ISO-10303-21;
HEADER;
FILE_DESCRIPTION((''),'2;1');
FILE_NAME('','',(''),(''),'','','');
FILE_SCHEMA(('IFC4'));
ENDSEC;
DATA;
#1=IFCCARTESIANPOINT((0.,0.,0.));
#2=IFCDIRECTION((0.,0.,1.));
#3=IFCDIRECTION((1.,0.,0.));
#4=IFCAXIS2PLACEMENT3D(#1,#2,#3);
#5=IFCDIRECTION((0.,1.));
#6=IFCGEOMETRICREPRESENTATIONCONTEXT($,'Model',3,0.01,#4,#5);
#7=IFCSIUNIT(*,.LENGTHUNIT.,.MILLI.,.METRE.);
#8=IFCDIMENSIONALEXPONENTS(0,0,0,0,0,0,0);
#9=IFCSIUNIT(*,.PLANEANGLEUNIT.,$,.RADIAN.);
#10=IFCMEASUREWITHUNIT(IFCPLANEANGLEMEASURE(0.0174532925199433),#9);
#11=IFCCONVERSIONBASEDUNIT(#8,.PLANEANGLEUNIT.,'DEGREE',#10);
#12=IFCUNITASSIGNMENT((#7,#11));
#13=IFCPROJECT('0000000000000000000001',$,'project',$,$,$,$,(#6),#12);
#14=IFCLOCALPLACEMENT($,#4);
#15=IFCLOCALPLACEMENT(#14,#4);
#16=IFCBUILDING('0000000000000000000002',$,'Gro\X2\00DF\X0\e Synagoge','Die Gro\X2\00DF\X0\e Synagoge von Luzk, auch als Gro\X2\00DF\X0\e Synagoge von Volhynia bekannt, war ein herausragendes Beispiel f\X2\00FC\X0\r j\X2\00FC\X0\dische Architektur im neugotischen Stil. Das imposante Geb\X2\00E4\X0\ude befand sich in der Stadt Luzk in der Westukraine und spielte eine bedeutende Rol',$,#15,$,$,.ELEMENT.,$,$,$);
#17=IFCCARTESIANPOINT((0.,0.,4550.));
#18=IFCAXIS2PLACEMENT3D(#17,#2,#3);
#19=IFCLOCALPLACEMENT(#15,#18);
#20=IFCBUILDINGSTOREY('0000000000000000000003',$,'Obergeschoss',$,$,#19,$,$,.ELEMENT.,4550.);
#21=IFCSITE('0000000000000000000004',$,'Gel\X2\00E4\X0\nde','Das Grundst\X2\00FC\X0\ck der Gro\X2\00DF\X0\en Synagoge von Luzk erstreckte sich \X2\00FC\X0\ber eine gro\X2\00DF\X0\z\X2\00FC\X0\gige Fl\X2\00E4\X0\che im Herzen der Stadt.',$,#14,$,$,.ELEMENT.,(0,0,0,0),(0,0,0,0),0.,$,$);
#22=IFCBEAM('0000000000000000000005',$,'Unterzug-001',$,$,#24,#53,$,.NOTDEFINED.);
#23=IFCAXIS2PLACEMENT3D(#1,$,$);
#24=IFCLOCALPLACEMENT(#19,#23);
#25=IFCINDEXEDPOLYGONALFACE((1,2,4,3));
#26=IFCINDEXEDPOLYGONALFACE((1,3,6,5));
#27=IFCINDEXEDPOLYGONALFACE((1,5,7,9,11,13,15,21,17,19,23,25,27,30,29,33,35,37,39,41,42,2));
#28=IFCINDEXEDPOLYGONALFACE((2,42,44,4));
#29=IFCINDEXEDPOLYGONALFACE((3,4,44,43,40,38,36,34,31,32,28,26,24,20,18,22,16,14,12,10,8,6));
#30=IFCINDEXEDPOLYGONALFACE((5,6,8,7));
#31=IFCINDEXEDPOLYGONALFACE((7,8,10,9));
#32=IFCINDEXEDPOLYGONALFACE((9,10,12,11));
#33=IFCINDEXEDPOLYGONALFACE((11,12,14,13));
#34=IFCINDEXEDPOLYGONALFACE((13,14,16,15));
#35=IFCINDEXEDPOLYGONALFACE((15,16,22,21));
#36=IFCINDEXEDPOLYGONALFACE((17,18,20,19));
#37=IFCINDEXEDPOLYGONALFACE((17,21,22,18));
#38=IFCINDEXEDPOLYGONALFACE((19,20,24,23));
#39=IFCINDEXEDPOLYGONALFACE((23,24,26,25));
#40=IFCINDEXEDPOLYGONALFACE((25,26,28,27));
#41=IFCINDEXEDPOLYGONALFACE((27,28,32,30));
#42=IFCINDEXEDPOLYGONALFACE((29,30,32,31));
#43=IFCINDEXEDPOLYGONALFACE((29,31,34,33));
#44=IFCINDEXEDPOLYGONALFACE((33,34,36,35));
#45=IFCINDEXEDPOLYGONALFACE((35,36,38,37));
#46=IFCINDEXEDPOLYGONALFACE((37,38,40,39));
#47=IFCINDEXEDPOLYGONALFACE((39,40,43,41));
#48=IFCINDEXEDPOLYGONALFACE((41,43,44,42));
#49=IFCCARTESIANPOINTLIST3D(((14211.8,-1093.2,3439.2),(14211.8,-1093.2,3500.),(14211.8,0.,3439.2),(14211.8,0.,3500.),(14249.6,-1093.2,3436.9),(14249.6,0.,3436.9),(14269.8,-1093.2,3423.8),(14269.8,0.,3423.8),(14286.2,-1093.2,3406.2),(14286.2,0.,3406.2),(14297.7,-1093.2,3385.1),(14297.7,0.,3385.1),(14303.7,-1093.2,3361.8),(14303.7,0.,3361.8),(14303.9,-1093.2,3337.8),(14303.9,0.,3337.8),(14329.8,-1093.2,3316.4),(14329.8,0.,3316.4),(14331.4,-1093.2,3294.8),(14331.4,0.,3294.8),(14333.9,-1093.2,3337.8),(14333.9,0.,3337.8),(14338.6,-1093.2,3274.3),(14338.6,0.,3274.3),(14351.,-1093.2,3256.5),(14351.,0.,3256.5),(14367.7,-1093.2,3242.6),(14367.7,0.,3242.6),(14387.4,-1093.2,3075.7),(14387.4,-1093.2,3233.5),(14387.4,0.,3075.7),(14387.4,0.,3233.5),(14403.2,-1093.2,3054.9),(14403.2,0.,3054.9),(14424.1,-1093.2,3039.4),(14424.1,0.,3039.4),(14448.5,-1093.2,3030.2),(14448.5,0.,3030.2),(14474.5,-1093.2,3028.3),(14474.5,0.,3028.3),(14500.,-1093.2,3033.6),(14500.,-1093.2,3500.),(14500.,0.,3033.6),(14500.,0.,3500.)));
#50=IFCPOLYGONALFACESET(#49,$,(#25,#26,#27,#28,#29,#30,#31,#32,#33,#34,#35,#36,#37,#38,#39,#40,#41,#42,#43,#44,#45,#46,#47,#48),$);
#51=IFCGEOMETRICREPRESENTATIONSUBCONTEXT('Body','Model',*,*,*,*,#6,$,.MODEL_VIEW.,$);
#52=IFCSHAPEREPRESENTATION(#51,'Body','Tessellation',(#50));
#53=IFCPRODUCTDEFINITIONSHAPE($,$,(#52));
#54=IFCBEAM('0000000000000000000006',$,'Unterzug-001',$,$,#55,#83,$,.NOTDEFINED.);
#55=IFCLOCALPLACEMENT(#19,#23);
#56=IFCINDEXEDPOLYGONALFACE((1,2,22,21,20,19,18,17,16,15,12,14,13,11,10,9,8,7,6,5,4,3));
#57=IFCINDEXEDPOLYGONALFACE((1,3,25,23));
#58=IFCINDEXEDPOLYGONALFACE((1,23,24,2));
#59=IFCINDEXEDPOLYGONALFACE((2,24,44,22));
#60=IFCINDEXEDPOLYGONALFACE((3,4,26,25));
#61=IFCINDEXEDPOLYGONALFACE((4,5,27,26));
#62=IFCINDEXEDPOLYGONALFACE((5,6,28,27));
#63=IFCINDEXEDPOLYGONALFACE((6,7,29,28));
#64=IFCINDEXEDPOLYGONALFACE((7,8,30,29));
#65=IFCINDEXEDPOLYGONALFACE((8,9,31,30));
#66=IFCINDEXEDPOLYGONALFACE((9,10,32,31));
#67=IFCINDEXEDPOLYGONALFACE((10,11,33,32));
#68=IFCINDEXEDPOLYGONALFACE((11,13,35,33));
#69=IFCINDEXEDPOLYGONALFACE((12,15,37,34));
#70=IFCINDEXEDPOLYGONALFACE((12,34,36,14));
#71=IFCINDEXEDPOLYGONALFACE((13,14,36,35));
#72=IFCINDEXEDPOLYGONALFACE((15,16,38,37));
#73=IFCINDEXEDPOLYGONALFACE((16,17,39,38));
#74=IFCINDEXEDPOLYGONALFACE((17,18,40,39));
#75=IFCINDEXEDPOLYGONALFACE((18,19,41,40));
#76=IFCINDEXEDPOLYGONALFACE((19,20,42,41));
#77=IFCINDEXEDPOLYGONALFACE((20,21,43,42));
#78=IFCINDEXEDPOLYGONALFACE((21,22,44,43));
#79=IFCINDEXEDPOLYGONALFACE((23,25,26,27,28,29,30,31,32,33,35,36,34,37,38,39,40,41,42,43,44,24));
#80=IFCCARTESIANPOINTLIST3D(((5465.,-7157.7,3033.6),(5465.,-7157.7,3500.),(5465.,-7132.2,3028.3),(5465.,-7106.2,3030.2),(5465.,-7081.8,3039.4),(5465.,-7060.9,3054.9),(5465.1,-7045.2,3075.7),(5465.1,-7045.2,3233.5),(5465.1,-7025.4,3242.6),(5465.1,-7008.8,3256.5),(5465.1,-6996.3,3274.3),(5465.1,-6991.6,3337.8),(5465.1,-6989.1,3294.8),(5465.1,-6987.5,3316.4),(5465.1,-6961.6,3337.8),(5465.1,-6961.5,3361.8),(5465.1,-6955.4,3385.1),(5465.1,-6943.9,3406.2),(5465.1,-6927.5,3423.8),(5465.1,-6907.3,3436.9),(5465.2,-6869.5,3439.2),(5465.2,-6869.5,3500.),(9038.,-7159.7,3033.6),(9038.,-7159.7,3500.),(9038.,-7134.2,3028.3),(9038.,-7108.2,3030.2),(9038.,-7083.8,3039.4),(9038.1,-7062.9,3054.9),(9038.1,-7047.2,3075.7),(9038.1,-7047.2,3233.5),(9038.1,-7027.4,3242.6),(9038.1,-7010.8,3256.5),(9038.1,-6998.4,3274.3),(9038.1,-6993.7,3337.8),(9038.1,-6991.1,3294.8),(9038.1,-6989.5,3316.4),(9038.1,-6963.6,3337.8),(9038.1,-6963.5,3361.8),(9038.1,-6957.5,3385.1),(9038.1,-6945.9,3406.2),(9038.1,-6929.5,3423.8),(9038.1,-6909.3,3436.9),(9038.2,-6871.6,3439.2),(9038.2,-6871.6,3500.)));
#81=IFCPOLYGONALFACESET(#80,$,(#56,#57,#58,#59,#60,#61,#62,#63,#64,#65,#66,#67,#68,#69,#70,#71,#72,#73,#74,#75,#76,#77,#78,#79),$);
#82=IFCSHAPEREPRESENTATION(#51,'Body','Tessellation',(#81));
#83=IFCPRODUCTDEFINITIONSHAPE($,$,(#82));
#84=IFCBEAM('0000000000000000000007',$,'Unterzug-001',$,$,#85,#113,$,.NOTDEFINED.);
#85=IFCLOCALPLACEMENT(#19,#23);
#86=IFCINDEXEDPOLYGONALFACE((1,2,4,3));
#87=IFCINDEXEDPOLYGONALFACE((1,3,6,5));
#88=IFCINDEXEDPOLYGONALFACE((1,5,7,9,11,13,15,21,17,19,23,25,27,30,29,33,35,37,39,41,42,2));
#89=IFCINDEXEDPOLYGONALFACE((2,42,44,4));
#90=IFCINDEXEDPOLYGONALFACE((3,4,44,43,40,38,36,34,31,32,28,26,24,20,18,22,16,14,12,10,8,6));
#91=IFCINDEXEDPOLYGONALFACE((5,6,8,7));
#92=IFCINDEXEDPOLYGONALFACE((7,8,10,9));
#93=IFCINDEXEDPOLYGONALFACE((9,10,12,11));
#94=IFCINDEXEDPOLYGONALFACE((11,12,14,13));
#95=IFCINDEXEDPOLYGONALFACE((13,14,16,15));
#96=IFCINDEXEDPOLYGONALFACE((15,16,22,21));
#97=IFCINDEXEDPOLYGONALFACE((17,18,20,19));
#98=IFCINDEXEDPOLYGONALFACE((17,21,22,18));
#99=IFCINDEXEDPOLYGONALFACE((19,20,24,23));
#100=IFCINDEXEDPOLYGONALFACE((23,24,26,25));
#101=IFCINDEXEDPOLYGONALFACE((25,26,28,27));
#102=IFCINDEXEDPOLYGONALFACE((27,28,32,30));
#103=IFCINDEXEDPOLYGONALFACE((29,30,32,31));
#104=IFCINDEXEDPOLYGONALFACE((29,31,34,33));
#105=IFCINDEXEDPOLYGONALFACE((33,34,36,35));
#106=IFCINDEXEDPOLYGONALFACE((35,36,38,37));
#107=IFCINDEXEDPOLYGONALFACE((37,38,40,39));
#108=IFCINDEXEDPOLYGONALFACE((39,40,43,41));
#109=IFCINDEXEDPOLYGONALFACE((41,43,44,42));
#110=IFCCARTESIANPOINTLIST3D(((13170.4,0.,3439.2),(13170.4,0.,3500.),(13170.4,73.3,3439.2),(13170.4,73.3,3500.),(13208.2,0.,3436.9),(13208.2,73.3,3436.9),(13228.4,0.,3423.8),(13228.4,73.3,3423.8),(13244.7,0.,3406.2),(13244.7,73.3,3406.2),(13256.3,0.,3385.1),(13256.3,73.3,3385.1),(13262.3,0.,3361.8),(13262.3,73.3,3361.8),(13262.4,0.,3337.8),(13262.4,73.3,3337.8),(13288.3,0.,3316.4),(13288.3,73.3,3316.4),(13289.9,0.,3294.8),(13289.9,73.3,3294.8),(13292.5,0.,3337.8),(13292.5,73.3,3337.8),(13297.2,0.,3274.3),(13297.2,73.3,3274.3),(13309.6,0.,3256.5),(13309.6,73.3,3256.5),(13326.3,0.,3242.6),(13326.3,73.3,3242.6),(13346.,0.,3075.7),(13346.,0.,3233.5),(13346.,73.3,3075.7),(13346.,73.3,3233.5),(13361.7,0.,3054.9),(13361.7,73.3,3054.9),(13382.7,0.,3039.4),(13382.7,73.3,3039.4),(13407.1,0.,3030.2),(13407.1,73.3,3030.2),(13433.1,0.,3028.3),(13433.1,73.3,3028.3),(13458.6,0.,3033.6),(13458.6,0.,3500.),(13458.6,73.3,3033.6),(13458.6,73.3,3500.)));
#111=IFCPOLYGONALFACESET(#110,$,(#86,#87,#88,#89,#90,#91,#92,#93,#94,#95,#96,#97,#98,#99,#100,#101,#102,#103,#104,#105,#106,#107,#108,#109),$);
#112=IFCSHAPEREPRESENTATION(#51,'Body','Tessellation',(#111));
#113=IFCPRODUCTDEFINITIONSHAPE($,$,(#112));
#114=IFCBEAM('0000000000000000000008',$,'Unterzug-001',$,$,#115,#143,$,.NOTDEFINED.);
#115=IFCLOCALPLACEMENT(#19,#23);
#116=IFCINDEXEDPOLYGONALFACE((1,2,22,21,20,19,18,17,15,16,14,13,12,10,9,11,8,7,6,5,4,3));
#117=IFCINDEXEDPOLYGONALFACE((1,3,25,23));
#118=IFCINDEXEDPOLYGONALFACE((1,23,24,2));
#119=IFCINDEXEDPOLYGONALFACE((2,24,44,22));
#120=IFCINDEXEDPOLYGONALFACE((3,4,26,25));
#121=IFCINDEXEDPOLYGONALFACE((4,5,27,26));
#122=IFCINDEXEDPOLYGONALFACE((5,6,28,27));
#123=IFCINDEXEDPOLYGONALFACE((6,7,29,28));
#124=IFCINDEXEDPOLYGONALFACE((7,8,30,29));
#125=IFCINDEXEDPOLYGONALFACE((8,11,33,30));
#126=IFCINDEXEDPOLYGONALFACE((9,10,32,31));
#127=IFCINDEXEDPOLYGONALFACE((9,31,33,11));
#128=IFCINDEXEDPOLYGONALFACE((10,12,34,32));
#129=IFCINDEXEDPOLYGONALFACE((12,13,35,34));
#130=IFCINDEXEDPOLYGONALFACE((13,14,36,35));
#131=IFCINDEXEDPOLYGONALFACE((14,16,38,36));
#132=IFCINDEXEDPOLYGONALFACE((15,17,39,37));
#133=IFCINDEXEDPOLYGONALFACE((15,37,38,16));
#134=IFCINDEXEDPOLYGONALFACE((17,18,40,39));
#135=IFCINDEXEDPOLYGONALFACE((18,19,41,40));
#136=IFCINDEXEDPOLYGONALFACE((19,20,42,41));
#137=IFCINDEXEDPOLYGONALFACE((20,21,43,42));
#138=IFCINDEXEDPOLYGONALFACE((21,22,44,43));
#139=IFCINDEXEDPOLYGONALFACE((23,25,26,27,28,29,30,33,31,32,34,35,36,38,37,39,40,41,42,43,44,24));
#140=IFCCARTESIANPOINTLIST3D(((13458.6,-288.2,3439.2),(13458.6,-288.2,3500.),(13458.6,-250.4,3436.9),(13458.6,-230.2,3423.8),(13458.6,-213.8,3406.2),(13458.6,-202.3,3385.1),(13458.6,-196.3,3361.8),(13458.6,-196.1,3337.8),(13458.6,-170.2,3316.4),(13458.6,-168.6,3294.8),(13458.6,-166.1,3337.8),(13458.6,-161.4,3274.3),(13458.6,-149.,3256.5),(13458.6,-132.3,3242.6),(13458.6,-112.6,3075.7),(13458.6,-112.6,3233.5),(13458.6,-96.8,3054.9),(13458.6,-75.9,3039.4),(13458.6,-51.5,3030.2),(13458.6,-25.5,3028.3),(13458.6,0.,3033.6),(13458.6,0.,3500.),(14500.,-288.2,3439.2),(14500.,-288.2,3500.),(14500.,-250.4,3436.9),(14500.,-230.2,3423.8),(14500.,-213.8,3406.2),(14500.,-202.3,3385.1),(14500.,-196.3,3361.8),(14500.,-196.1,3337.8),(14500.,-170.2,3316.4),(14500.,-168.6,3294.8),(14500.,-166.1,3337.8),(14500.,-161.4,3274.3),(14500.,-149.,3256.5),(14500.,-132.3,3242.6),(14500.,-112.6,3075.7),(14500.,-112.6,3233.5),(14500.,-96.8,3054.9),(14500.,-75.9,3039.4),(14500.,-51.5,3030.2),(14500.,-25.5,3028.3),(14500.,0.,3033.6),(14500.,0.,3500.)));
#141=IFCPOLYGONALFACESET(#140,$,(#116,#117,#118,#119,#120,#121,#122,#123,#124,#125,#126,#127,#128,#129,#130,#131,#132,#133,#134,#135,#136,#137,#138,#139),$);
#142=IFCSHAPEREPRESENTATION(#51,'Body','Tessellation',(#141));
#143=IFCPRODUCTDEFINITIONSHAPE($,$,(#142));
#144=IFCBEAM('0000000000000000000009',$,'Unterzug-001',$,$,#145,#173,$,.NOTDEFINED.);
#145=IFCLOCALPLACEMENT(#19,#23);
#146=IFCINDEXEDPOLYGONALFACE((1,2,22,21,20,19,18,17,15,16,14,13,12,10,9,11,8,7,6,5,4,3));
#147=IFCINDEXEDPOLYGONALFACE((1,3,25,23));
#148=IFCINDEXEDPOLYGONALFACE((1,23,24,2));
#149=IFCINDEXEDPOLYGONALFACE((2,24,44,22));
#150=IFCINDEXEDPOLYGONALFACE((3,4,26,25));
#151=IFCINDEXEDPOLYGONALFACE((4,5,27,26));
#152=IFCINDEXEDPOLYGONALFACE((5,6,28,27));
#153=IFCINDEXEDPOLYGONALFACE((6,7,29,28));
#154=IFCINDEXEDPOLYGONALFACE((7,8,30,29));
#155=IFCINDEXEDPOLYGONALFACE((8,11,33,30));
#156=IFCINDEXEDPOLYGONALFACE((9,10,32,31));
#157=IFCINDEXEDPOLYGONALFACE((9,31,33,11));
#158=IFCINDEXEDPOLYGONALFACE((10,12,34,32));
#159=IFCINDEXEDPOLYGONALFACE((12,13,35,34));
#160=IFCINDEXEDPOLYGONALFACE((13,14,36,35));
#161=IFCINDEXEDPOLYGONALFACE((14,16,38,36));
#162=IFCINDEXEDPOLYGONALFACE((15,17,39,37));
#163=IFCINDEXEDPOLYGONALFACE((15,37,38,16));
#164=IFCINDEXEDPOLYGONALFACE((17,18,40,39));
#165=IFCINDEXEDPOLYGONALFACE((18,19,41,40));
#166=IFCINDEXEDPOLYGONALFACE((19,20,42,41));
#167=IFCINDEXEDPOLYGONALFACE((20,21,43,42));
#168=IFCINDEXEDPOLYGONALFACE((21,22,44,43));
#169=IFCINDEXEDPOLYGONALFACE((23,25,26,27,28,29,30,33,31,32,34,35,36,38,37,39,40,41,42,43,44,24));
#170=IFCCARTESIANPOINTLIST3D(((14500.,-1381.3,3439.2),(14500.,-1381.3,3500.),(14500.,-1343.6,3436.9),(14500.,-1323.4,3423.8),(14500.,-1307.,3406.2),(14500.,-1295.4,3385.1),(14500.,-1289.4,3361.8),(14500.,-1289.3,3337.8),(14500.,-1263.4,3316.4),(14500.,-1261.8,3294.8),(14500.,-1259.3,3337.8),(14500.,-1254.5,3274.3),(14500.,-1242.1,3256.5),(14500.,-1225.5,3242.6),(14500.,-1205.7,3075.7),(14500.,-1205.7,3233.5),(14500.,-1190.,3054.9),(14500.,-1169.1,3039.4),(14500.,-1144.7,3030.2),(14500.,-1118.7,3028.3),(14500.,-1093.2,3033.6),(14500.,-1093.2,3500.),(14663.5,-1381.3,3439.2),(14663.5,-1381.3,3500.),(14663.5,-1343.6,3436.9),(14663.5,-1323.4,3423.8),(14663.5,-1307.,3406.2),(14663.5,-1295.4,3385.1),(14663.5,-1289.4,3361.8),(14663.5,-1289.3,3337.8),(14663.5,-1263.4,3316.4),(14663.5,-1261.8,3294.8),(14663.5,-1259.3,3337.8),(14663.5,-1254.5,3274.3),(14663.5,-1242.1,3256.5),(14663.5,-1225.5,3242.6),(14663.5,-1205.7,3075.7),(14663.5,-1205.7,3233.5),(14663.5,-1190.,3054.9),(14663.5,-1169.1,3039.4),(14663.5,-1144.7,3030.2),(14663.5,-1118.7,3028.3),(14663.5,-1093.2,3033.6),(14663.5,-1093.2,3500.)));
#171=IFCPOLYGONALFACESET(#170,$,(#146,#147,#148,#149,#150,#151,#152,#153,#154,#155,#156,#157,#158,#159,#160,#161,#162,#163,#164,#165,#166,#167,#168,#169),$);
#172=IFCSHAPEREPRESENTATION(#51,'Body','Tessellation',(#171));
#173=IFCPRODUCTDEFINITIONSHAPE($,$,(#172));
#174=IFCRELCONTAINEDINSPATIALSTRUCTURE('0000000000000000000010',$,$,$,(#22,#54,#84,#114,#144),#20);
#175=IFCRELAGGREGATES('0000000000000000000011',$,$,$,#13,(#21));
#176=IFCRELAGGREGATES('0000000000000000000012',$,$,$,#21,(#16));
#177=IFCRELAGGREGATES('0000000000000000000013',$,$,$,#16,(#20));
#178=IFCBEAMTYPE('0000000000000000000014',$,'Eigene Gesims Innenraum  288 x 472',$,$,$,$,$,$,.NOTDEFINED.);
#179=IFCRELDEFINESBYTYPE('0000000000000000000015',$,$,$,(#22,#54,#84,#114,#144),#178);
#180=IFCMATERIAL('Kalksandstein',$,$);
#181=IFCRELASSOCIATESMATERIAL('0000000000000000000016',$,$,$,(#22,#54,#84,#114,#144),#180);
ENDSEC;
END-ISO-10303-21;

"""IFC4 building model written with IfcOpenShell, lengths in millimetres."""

from ifc_helpers import new_model, entity, si_unit, converted_unit, direction, frame, origin_with_axes, place, context, subcontext, project, spatial, line, arc, indexed_curve, outline, extrude, material, material_profile, profile_set, type_object, element, save


model = new_model("IFC4")

# Units and contexts
model_context = context("Model", 3, precision=0.01, world=origin_with_axes(), true_north=direction((0.0, 1.0)))
body_context = subcontext(model_context, "Body", "Model", "MODEL_VIEW")
ifc_project = project(units=[si_unit("LENGTHUNIT", "METRE", prefix="MILLI"), converted_unit("PLANEANGLEUNIT", "DEGREE", entity("IfcPlaneAngleMeasure", 0.0174532925199433), si_unit("PLANEANGLEUNIT", "RADIAN"), dimensions=[0, 0, 0, 0, 0, 0, 0])], contexts=[model_context])

# Site, building, storey
site_placement = place(None, origin_with_axes())
site = spatial("IfcSite", under=ifc_project, at=site_placement, Name="Gelände", Description="Das Grundstück der Großen Synagoge von Luzk erstreckte sich über eine großzügige Fläche im Herzen der Stadt.", CompositionType="ELEMENT", RefLatitude=(0, 0, 0, 0), RefLongitude=(0, 0, 0, 0), RefElevation=0.0)
building_placement = place(site_placement, origin_with_axes())
building = spatial("IfcBuilding", under=site, at=building_placement, Name="Große Synagoge", Description="Die Große Synagoge von Luzk, auch als Große Synagoge von Volhynia bekannt, war ein herausragendes Beispiel für jüdische Architektur im neugotischen Stil. Das imposante Gebäude befand sich in der Stadt Luzk in der Westukraine und spielte eine bedeutende Rol", CompositionType="ELEMENT")
storey_placement = place(building_placement, frame((0.0, 0.0, 4550.0), z_axis=(0.0, 0.0, 1.0), x_axis=(1.0, 0.0, 0.0)))
storey = spatial("IfcBuildingStorey", under=building, at=storey_placement, Name="Obergeschoss", CompositionType="ELEMENT", Elevation=4550.0)

# Beams
ifc_material_1 = material(Name="Kalksandstein")
ifc_material_profile_1 = material_profile(ifc_material_1, outline(indexed_curve([(0.0, 0.0), (0.0, -466.4), (64.0, -466.1), (112.6, -424.3), (112.6, -266.5), (161.4, -225.7), (166.1, -162.2), (196.1, -162.2), (207.4, -104.0), (250.4, -63.1), (288.2, -60.8), (288.2, 0.0)], segments=[line(1, 2), arc(2, 3, 4), line(4, 5), arc(5, 6, 7), line(7, 8), arc(8, 9, 10), line(10, 11, 12, 1)])), Name="Kalksandstein")
ifc_profile_set_1 = profile_set([ifc_material_profile_1], Name="Eigene Gesims Innenraum ")
beam_type_1 = type_object("IfcBeamType", Name="Eigene Gesims Innenraum  288 x 472", PredefinedType="NOTDEFINED")
beam_1_placement = place(storey_placement, frame((14500.0, 0.0, 3500.0), z_axis=(0.0, 0.0, 1.0), x_axis=(-1.0, 0.0, 0.0)))
element("IfcBeam", 1, at=beam_1_placement, inside=storey, type_object=beam_type_1, material=ifc_profile_set_1, Name="Unterzug-001", PredefinedType="NOTDEFINED", context=body_context, shape_type="SweptSolid", body=[
    extrude(outline(indexed_curve([(0.0, 0.0), (0.0, -466.4), (64.0, -466.1), (112.6, -424.3), (112.6, -266.5), (161.4, -225.7), (166.1, -162.2), (196.1, -162.2), (207.4, -104.0), (250.4, -63.1), (288.2, -60.8), (288.2, 0.0)], segments=[line(1, 2), arc(2, 3, 4), line(4, 5), arc(5, 6, 7), line(7, 8), arc(8, 9, 10), line(10, 11, 12, 1)])), frame((0.0, 1093.2, 0.0), z_axis=(0.0, -1.0, 0.0), x_axis=(1.0, 0.0, 0.0)), (0.0, 0.0, 1.0), 1093.2),
])
beam_2_placement = place(storey_placement, frame((9038.0, -7159.7, 3500.0), z_axis=(0.0, 0.0, 1.0), x_axis=(0.000564, 1.0, 0.0)))
element("IfcBeam", 2, at=beam_2_placement, inside=storey, type_object=beam_type_1, material=ifc_profile_set_1, Name="Unterzug-001", PredefinedType="NOTDEFINED", context=body_context, shape_type="SweptSolid", body=[
    extrude(outline(indexed_curve([(0.0, 0.0), (0.0, -466.4), (64.0, -466.1), (112.6, -424.3), (112.6, -266.5), (161.4, -225.7), (166.1, -162.2), (196.1, -162.2), (207.4, -104.0), (250.4, -63.1), (288.2, -60.8), (288.2, 0.0)], segments=[line(1, 2), arc(2, 3, 4), line(4, 5), arc(5, 6, 7), line(7, 8), arc(8, 9, 10), line(10, 11, 12, 1)])), frame((0.0, 3573.0, 0.0), z_axis=(0.0, -1.0, 0.0), x_axis=(1.0, 0.0, 0.0)), (0.0, 0.0, 1.0), 3573.0),
])
beam_3_placement = place(storey_placement, frame((13458.6, 73.3, 3500.0), z_axis=(0.0, 0.0, 1.0), x_axis=(-1.0, 0.0, 0.0)))
element("IfcBeam", 3, at=beam_3_placement, inside=storey, type_object=beam_type_1, material=ifc_profile_set_1, Name="Unterzug-001", PredefinedType="NOTDEFINED", context=body_context, shape_type="SweptSolid", body=[
    extrude(outline(indexed_curve([(0.0, 0.0), (0.0, -466.4), (64.0, -466.1), (112.6, -424.3), (112.6, -266.5), (161.4, -225.7), (166.1, -162.2), (196.1, -162.2), (207.4, -104.0), (250.4, -63.1), (288.2, -60.8), (288.2, 0.0)], segments=[line(1, 2), arc(2, 3, 4), line(4, 5), arc(5, 6, 7), line(7, 8), arc(8, 9, 10), line(10, 11, 12, 1)])), frame((0.0, 73.3, 0.0), z_axis=(0.0, -1.0, 0.0), x_axis=(1.0, 0.0, 0.0)), (0.0, 0.0, 1.0), 73.3),
])
beam_4_placement = place(storey_placement, frame((13458.6, 0.0, 3500.0), z_axis=(0.0, 0.0, 1.0), x_axis=(0.0, -1.0, 0.0)))
element("IfcBeam", 4, at=beam_4_placement, inside=storey, type_object=beam_type_1, material=ifc_profile_set_1, Name="Unterzug-001", PredefinedType="NOTDEFINED", context=body_context, shape_type="SweptSolid", body=[
    extrude(outline(indexed_curve([(0.0, 0.0), (0.0, -466.4), (64.0, -466.1), (112.6, -424.3), (112.6, -266.5), (161.4, -225.7), (166.1, -162.2), (196.1, -162.2), (207.4, -104.0), (250.4, -63.1), (288.2, -60.8), (288.2, 0.0)], segments=[line(1, 2), arc(2, 3, 4), line(4, 5), arc(5, 6, 7), line(7, 8), arc(8, 9, 10), line(10, 11, 12, 1)])), frame((0.0, 1041.4, 0.0), z_axis=(0.0, -1.0, 0.0), x_axis=(1.0, 0.0, 0.0)), (0.0, 0.0, 1.0), 1041.4),
])
beam_5_placement = place(storey_placement, frame((14500.0, -1093.2, 3500.0), z_axis=(0.0, 0.0, 1.0), x_axis=(0.0, -1.0, 0.0)))
element("IfcBeam", 5, at=beam_5_placement, inside=storey, type_object=beam_type_1, material=ifc_profile_set_1, Name="Unterzug-001", PredefinedType="NOTDEFINED", context=body_context, shape_type="SweptSolid", body=[
    extrude(outline(indexed_curve([(0.0, 0.0), (0.0, -466.4), (64.0, -466.1), (112.6, -424.3), (112.6, -266.5), (161.4, -225.7), (166.1, -162.2), (196.1, -162.2), (207.4, -104.0), (250.4, -63.1), (288.2, -60.8), (288.2, 0.0)], segments=[line(1, 2), arc(2, 3, 4), line(4, 5), arc(5, 6, 7), line(7, 8), arc(8, 9, 10), line(10, 11, 12, 1)])), frame((0.0, 163.5, 0.0), z_axis=(0.0, -1.0, 0.0), x_axis=(1.0, 0.0, 0.0)), (0.0, 0.0, 1.0), 163.5),
])

save(model, "model.ifc")
